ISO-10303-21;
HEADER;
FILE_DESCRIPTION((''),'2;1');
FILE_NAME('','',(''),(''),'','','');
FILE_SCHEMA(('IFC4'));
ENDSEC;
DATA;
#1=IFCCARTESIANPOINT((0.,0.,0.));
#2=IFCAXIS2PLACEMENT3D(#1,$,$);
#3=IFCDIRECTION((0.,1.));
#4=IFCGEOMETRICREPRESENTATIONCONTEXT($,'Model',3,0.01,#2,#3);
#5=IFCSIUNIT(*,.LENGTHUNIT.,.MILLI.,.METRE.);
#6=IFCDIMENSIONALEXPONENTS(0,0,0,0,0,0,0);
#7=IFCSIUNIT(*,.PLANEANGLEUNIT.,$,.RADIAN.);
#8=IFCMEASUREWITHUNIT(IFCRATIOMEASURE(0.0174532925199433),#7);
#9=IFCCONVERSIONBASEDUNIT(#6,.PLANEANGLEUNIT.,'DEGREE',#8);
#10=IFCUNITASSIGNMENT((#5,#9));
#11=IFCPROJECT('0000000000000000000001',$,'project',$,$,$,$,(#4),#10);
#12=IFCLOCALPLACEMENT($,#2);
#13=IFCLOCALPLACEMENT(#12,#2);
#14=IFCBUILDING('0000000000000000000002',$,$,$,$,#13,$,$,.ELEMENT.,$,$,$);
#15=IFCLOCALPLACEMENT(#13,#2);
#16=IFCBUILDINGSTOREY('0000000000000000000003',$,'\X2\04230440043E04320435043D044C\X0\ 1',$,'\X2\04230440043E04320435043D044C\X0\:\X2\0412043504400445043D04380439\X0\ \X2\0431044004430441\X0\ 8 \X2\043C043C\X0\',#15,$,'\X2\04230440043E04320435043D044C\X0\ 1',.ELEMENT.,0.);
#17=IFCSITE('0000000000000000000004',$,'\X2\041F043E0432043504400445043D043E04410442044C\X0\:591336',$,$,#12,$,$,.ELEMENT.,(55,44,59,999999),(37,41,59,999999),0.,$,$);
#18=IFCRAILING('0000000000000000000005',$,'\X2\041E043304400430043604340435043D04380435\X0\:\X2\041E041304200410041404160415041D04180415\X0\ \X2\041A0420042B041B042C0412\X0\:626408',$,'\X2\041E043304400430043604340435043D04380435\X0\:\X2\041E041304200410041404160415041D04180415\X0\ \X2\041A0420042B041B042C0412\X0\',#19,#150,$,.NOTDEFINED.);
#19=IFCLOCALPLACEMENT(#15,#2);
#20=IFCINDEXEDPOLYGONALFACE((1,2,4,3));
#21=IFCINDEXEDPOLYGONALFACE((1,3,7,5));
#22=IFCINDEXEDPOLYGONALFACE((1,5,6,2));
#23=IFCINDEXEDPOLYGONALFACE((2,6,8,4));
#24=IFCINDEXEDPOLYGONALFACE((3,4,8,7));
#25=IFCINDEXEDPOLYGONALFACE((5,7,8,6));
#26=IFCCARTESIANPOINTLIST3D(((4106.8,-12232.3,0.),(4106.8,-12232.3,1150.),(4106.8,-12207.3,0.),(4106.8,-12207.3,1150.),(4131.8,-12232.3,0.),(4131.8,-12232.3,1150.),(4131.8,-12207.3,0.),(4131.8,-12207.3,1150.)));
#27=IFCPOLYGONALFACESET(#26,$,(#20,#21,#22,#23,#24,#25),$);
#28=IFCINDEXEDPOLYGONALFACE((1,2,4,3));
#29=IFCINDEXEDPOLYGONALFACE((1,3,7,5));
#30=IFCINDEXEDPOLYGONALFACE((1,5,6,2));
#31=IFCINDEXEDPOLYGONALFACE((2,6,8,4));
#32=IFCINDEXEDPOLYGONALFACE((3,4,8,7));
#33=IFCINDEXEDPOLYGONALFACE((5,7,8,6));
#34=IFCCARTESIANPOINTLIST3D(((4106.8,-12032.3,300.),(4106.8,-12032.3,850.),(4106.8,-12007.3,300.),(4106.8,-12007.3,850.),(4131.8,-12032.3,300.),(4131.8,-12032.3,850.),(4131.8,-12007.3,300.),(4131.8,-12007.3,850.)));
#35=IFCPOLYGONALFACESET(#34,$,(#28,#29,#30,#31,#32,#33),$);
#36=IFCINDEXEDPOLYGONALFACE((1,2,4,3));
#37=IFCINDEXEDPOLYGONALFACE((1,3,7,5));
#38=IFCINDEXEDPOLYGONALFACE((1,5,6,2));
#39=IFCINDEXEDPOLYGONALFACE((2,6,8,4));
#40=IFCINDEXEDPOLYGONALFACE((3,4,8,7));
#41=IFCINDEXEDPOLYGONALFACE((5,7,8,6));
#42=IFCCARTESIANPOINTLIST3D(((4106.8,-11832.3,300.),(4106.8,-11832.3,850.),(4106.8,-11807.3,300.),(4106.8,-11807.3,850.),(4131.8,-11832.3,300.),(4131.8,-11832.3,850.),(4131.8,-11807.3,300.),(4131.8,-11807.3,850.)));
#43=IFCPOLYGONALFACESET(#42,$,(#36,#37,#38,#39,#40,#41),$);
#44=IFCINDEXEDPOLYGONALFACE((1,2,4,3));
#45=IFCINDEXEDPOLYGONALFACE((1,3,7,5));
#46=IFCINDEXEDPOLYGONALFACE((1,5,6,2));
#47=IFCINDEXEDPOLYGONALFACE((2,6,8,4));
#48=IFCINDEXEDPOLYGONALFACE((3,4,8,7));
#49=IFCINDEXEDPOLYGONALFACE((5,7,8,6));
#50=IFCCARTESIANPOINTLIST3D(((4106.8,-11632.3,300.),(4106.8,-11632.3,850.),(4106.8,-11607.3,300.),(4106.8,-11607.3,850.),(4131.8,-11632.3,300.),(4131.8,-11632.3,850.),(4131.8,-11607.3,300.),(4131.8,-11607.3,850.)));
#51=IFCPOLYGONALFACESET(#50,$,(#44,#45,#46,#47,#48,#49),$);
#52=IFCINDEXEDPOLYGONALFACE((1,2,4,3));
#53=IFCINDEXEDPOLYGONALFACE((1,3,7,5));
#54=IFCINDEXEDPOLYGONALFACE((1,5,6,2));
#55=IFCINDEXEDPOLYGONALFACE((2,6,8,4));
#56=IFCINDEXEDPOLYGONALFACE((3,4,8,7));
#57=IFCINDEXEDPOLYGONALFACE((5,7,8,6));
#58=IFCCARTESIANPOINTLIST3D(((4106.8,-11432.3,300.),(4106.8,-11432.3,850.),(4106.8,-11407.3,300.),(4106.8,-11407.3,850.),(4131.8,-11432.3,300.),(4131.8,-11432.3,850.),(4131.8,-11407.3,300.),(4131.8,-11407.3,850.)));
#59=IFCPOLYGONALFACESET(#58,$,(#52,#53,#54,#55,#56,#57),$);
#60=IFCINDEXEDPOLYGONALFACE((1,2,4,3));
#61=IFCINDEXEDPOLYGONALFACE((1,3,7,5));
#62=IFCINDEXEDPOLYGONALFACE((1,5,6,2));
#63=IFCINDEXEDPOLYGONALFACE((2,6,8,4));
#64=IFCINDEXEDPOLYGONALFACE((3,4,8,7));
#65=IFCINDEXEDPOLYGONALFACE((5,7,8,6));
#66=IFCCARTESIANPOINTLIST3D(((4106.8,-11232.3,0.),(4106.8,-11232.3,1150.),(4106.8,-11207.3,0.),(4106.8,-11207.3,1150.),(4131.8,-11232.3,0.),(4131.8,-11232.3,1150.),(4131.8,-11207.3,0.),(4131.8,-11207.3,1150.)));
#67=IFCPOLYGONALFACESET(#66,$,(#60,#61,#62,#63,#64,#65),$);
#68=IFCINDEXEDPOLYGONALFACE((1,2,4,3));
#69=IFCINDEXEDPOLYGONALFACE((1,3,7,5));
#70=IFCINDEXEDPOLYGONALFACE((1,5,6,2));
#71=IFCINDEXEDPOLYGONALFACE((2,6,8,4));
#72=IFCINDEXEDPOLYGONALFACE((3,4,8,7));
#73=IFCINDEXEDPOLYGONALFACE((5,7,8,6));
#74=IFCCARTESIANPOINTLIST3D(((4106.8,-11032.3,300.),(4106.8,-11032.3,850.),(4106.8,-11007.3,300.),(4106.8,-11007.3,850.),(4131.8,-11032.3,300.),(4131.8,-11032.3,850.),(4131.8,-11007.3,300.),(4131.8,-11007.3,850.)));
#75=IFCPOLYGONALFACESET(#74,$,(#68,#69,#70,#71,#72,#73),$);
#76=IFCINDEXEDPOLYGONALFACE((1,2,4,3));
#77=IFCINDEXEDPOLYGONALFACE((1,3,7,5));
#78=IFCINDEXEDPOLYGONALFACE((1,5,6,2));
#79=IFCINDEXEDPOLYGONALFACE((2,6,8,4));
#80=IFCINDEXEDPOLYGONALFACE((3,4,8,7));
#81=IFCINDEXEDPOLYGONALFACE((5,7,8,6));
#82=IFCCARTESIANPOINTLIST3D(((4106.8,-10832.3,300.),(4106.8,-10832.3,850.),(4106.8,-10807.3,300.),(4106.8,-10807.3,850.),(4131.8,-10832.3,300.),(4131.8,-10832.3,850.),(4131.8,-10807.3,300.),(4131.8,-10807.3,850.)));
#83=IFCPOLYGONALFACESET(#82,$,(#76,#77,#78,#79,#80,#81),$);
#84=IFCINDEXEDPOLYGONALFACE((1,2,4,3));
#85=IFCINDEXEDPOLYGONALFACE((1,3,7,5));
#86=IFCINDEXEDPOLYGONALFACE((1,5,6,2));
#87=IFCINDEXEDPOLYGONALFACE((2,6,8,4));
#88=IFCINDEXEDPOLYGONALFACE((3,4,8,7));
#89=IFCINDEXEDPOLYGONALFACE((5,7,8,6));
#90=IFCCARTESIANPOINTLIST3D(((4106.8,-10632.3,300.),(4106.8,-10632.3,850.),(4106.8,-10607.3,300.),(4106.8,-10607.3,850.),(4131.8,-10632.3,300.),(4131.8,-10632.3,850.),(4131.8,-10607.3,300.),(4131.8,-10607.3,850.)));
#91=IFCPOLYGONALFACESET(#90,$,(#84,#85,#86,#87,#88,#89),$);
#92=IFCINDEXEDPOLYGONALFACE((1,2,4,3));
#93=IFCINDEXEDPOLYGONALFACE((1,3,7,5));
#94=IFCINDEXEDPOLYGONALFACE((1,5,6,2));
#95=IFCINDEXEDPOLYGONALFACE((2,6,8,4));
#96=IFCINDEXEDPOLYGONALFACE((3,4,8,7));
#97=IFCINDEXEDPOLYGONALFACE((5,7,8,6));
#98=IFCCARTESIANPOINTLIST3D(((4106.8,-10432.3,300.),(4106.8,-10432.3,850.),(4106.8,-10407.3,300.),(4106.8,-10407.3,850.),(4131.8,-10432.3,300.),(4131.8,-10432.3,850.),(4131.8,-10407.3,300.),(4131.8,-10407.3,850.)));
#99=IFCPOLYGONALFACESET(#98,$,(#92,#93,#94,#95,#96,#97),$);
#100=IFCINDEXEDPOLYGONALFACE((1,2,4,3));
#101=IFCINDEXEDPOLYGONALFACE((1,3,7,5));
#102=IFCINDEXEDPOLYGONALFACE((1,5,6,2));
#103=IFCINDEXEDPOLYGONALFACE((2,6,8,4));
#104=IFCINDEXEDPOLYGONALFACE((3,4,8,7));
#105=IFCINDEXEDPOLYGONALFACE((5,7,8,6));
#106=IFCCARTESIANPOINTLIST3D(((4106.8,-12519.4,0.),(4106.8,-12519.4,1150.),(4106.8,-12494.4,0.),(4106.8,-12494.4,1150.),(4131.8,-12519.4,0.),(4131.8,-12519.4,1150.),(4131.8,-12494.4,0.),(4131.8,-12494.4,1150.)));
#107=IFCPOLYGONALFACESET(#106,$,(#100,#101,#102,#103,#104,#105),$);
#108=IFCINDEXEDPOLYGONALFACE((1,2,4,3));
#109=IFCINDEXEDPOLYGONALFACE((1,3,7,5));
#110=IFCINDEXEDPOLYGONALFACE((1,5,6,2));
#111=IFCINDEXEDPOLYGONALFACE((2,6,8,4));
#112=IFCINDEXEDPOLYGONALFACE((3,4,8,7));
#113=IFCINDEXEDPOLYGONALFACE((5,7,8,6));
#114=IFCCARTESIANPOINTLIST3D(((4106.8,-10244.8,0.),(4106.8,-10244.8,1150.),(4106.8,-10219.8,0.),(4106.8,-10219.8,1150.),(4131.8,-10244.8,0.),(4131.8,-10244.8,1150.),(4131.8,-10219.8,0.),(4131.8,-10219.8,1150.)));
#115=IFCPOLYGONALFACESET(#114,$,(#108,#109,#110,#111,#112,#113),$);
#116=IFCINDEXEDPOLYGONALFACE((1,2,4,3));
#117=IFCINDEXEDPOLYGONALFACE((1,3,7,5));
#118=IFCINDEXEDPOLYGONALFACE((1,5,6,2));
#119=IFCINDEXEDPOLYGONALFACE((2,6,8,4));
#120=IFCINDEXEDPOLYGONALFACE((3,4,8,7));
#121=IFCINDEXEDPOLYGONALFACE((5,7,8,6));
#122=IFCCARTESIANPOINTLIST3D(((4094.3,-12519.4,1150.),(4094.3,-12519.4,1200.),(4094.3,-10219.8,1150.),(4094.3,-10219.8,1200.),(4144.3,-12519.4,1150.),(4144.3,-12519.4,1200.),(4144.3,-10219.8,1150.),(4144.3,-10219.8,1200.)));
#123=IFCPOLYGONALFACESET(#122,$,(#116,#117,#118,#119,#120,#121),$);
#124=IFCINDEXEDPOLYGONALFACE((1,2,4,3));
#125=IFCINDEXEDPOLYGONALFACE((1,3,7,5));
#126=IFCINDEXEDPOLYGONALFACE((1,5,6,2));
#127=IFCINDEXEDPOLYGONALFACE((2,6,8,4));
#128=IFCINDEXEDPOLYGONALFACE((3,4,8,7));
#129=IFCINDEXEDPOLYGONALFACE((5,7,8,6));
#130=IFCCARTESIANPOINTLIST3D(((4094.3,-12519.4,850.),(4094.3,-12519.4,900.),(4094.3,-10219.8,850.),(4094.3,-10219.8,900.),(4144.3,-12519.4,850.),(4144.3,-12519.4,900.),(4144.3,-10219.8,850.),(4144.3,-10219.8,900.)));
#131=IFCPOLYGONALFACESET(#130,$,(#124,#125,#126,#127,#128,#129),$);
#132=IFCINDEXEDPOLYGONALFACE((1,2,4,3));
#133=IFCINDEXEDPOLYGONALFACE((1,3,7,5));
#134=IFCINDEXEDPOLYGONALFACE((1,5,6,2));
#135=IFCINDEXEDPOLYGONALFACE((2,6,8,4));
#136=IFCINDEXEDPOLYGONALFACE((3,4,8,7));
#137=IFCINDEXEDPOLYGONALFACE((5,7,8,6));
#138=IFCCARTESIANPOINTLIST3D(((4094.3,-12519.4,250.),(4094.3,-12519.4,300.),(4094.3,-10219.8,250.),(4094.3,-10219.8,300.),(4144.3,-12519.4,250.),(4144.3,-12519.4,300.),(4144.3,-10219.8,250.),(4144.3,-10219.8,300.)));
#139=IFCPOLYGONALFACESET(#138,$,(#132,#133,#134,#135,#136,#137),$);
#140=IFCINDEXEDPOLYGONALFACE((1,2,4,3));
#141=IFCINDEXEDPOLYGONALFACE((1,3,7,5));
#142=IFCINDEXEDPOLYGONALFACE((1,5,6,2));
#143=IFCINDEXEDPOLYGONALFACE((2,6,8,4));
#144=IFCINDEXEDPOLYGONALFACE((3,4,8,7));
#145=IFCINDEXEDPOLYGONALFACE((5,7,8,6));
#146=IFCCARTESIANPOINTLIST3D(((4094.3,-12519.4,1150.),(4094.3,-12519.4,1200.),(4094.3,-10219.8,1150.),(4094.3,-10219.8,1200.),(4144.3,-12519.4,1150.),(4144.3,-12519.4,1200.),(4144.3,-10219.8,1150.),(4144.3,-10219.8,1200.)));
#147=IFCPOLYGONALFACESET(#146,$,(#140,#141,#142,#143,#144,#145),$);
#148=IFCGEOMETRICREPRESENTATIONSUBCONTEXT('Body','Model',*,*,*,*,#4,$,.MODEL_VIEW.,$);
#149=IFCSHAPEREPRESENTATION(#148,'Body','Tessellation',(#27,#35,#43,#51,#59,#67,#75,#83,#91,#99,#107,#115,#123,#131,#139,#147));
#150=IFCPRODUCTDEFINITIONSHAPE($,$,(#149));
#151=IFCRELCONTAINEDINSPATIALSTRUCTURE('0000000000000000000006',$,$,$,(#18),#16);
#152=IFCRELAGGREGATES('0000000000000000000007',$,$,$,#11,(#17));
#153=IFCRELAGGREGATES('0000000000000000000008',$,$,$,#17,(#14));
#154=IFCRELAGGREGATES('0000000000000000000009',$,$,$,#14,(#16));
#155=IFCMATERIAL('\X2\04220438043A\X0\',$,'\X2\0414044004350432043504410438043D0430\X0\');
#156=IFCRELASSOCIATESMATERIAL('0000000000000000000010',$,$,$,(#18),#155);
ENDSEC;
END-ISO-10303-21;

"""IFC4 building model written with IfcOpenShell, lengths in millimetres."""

from ifc_helpers import new_model, entity, si_unit, converted_unit, direction, frame, origin, place, context, subcontext, project, spatial, indexed_curve, outline, extrude, material, element, save


model = new_model("IFC4")

# Units and contexts
model_context = context("Model", 3, precision=0.01, world=origin(), true_north=direction((0.0, 1.0)))
body_context = subcontext(model_context, "Body", "Model", "MODEL_VIEW")
ifc_project = project(units=[si_unit("LENGTHUNIT", "METRE", prefix="MILLI"), converted_unit("PLANEANGLEUNIT", "DEGREE", entity("IfcRatioMeasure", 0.0174532925199433), si_unit("PLANEANGLEUNIT", "RADIAN"), dimensions=[0, 0, 0, 0, 0, 0, 0])], contexts=[model_context])

# Site, building, storey
site_placement = place(None, origin())
site = spatial("IfcSite", under=ifc_project, at=site_placement, Name="Поверхность:591336", CompositionType="ELEMENT", RefLatitude=(55, 44, 59, 999999), RefLongitude=(37, 41, 59, 999999), RefElevation=0.0)
building_placement = place(site_placement, origin())
building = spatial("IfcBuilding", under=site, at=building_placement, CompositionType="ELEMENT")
storey_placement = place(building_placement, origin())
storey = spatial("IfcBuildingStorey", under=building, at=storey_placement, Name="Уровень 1", ObjectType="Уровень:Верхний брус 8 мм", LongName="Уровень 1", CompositionType="ELEMENT", Elevation=0.0)

# Railing
ifc_material_1 = material(Name="Тик", Category="Древесина")
railing_1_placement = place(storey_placement, origin())
element("IfcRailing", 1, at=railing_1_placement, inside=storey, material=ifc_material_1, Name="Ограждение:ОГРАДЖЕНИЕ КРЫЛЬВ:626408", ObjectType="Ограждение:ОГРАДЖЕНИЕ КРЫЛЬВ", PredefinedType="NOTDEFINED", context=body_context, shape_type="SweptSolid", body=[
    extrude(outline(indexed_curve([(-12.5, -12.5), (12.5, -12.5), (12.5, 12.5), (-12.5, 12.5), (-12.5, -12.5)], self_intersect=False)), frame((4119.3, -12219.8, 0.0), z_axis=(0.0, 0.0, 1.0), x_axis=(-1.0, 0.0, 0.0)), (0.0, 0.0, 1.0), 1150.0),
    extrude(outline(indexed_curve([(-12.5, -12.5), (12.5, -12.5), (12.5, 12.5), (-12.5, 12.5), (-12.5, -12.5)], self_intersect=False)), frame((4119.3, -12019.8, 300.0), z_axis=(0.0, 0.0, 1.0), x_axis=(-1.0, 0.0, 0.0)), (0.0, 0.0, 1.0), 550.0),
    extrude(outline(indexed_curve([(-12.5, -12.5), (12.5, -12.5), (12.5, 12.5), (-12.5, 12.5), (-12.5, -12.5)], self_intersect=False)), frame((4119.3, -11819.8, 300.0), z_axis=(0.0, 0.0, 1.0), x_axis=(-1.0, 0.0, 0.0)), (0.0, 0.0, 1.0), 550.0),
    extrude(outline(indexed_curve([(-12.5, -12.5), (12.5, -12.5), (12.5, 12.5), (-12.5, 12.5), (-12.5, -12.5)], self_intersect=False)), frame((4119.3, -11619.8, 300.0), z_axis=(0.0, 0.0, 1.0), x_axis=(-1.0, 0.0, 0.0)), (0.0, 0.0, 1.0), 550.0),
    extrude(outline(indexed_curve([(-12.5, -12.5), (12.5, -12.5), (12.5, 12.5), (-12.5, 12.5), (-12.5, -12.5)], self_intersect=False)), frame((4119.3, -11419.8, 300.0), z_axis=(0.0, 0.0, 1.0), x_axis=(-1.0, 0.0, 0.0)), (0.0, 0.0, 1.0), 550.0),
    extrude(outline(indexed_curve([(-12.5, -12.5), (12.5, -12.5), (12.5, 12.5), (-12.5, 12.5), (-12.5, -12.5)], self_intersect=False)), frame((4119.3, -11219.8, 0.0), z_axis=(0.0, 0.0, 1.0), x_axis=(-1.0, 0.0, 0.0)), (0.0, 0.0, 1.0), 1150.0),
    extrude(outline(indexed_curve([(-12.5, -12.5), (12.5, -12.5), (12.5, 12.5), (-12.5, 12.5), (-12.5, -12.5)], self_intersect=False)), frame((4119.3, -11019.8, 300.0), z_axis=(0.0, 0.0, 1.0), x_axis=(-1.0, 0.0, 0.0)), (0.0, 0.0, 1.0), 550.0),
    extrude(outline(indexed_curve([(-12.5, -12.5), (12.5, -12.5), (12.5, 12.5), (-12.5, 12.5), (-12.5, -12.5)], self_intersect=False)), frame((4119.3, -10819.8, 300.0), z_axis=(0.0, 0.0, 1.0), x_axis=(-1.0, 0.0, 0.0)), (0.0, 0.0, 1.0), 550.0),
    extrude(outline(indexed_curve([(-12.5, -12.5), (12.5, -12.5), (12.5, 12.5), (-12.5, 12.5), (-12.5, -12.5)], self_intersect=False)), frame((4119.3, -10619.8, 300.0), z_axis=(0.0, 0.0, 1.0), x_axis=(-1.0, 0.0, 0.0)), (0.0, 0.0, 1.0), 550.0),
    extrude(outline(indexed_curve([(-12.5, -12.5), (12.5, -12.5), (12.5, 12.5), (-12.5, 12.5), (-12.5, -12.5)], self_intersect=False)), frame((4119.3, -10419.8, 300.0), z_axis=(0.0, 0.0, 1.0), x_axis=(-1.0, 0.0, 0.0)), (0.0, 0.0, 1.0), 550.0),
    extrude(outline(indexed_curve([(-12.5, -12.5), (12.5, -12.5), (12.5, 12.5), (-12.5, 12.5), (-12.5, -12.5)], self_intersect=False)), frame((4119.3, -12506.9, 0.0), z_axis=(0.0, 0.0, 1.0), x_axis=(-1.0, 0.0, 0.0)), (0.0, 0.0, 1.0), 1150.0),
    extrude(outline(indexed_curve([(-12.5, -12.5), (12.5, -12.5), (12.5, 12.5), (-12.5, 12.5), (-12.5, -12.5)], self_intersect=False)), frame((4119.3, -10232.3, 0.0), z_axis=(0.0, 0.0, 1.0), x_axis=(-1.0, 0.0, 0.0)), (0.0, 0.0, 1.0), 1150.0),
    extrude(outline(indexed_curve([(-1149.8, -25.0), (1149.8, -25.0), (1149.8, 25.0), (-1149.8, 25.0), (-1149.8, -25.0)], self_intersect=False)), frame((4119.3, -11369.6, 1150.0), z_axis=(0.0, 0.0, 1.0), x_axis=(0.0, -1.0, 0.0)), (0.0, 0.0, 1.0), 50.0),
    extrude(outline(indexed_curve([(-1149.8, -25.0), (1149.8, -25.0), (1149.8, 25.0), (-1149.8, 25.0), (-1149.8, -25.0)], self_intersect=False)), frame((4119.3, -11369.6, 850.0), z_axis=(0.0, 0.0, 1.0), x_axis=(0.0, -1.0, 0.0)), (0.0, 0.0, 1.0), 50.0),
    extrude(outline(indexed_curve([(-1149.8, -25.0), (1149.8, -25.0), (1149.8, 25.0), (-1149.8, 25.0), (-1149.8, -25.0)], self_intersect=False)), frame((4119.3, -11369.6, 250.0), z_axis=(0.0, 0.0, 1.0), x_axis=(0.0, -1.0, 0.0)), (0.0, 0.0, 1.0), 50.0),
    extrude(outline(indexed_curve([(-1149.8, -25.0), (1149.8, -25.0), (1149.8, 25.0), (-1149.8, 25.0), (-1149.8, -25.0)], self_intersect=False)), frame((4119.3, -11369.6, 1150.0), z_axis=(0.0, 0.0, 1.0), x_axis=(0.0, -1.0, 0.0)), (0.0, 0.0, 1.0), 50.0),
])

save(model, "model.ifc")
